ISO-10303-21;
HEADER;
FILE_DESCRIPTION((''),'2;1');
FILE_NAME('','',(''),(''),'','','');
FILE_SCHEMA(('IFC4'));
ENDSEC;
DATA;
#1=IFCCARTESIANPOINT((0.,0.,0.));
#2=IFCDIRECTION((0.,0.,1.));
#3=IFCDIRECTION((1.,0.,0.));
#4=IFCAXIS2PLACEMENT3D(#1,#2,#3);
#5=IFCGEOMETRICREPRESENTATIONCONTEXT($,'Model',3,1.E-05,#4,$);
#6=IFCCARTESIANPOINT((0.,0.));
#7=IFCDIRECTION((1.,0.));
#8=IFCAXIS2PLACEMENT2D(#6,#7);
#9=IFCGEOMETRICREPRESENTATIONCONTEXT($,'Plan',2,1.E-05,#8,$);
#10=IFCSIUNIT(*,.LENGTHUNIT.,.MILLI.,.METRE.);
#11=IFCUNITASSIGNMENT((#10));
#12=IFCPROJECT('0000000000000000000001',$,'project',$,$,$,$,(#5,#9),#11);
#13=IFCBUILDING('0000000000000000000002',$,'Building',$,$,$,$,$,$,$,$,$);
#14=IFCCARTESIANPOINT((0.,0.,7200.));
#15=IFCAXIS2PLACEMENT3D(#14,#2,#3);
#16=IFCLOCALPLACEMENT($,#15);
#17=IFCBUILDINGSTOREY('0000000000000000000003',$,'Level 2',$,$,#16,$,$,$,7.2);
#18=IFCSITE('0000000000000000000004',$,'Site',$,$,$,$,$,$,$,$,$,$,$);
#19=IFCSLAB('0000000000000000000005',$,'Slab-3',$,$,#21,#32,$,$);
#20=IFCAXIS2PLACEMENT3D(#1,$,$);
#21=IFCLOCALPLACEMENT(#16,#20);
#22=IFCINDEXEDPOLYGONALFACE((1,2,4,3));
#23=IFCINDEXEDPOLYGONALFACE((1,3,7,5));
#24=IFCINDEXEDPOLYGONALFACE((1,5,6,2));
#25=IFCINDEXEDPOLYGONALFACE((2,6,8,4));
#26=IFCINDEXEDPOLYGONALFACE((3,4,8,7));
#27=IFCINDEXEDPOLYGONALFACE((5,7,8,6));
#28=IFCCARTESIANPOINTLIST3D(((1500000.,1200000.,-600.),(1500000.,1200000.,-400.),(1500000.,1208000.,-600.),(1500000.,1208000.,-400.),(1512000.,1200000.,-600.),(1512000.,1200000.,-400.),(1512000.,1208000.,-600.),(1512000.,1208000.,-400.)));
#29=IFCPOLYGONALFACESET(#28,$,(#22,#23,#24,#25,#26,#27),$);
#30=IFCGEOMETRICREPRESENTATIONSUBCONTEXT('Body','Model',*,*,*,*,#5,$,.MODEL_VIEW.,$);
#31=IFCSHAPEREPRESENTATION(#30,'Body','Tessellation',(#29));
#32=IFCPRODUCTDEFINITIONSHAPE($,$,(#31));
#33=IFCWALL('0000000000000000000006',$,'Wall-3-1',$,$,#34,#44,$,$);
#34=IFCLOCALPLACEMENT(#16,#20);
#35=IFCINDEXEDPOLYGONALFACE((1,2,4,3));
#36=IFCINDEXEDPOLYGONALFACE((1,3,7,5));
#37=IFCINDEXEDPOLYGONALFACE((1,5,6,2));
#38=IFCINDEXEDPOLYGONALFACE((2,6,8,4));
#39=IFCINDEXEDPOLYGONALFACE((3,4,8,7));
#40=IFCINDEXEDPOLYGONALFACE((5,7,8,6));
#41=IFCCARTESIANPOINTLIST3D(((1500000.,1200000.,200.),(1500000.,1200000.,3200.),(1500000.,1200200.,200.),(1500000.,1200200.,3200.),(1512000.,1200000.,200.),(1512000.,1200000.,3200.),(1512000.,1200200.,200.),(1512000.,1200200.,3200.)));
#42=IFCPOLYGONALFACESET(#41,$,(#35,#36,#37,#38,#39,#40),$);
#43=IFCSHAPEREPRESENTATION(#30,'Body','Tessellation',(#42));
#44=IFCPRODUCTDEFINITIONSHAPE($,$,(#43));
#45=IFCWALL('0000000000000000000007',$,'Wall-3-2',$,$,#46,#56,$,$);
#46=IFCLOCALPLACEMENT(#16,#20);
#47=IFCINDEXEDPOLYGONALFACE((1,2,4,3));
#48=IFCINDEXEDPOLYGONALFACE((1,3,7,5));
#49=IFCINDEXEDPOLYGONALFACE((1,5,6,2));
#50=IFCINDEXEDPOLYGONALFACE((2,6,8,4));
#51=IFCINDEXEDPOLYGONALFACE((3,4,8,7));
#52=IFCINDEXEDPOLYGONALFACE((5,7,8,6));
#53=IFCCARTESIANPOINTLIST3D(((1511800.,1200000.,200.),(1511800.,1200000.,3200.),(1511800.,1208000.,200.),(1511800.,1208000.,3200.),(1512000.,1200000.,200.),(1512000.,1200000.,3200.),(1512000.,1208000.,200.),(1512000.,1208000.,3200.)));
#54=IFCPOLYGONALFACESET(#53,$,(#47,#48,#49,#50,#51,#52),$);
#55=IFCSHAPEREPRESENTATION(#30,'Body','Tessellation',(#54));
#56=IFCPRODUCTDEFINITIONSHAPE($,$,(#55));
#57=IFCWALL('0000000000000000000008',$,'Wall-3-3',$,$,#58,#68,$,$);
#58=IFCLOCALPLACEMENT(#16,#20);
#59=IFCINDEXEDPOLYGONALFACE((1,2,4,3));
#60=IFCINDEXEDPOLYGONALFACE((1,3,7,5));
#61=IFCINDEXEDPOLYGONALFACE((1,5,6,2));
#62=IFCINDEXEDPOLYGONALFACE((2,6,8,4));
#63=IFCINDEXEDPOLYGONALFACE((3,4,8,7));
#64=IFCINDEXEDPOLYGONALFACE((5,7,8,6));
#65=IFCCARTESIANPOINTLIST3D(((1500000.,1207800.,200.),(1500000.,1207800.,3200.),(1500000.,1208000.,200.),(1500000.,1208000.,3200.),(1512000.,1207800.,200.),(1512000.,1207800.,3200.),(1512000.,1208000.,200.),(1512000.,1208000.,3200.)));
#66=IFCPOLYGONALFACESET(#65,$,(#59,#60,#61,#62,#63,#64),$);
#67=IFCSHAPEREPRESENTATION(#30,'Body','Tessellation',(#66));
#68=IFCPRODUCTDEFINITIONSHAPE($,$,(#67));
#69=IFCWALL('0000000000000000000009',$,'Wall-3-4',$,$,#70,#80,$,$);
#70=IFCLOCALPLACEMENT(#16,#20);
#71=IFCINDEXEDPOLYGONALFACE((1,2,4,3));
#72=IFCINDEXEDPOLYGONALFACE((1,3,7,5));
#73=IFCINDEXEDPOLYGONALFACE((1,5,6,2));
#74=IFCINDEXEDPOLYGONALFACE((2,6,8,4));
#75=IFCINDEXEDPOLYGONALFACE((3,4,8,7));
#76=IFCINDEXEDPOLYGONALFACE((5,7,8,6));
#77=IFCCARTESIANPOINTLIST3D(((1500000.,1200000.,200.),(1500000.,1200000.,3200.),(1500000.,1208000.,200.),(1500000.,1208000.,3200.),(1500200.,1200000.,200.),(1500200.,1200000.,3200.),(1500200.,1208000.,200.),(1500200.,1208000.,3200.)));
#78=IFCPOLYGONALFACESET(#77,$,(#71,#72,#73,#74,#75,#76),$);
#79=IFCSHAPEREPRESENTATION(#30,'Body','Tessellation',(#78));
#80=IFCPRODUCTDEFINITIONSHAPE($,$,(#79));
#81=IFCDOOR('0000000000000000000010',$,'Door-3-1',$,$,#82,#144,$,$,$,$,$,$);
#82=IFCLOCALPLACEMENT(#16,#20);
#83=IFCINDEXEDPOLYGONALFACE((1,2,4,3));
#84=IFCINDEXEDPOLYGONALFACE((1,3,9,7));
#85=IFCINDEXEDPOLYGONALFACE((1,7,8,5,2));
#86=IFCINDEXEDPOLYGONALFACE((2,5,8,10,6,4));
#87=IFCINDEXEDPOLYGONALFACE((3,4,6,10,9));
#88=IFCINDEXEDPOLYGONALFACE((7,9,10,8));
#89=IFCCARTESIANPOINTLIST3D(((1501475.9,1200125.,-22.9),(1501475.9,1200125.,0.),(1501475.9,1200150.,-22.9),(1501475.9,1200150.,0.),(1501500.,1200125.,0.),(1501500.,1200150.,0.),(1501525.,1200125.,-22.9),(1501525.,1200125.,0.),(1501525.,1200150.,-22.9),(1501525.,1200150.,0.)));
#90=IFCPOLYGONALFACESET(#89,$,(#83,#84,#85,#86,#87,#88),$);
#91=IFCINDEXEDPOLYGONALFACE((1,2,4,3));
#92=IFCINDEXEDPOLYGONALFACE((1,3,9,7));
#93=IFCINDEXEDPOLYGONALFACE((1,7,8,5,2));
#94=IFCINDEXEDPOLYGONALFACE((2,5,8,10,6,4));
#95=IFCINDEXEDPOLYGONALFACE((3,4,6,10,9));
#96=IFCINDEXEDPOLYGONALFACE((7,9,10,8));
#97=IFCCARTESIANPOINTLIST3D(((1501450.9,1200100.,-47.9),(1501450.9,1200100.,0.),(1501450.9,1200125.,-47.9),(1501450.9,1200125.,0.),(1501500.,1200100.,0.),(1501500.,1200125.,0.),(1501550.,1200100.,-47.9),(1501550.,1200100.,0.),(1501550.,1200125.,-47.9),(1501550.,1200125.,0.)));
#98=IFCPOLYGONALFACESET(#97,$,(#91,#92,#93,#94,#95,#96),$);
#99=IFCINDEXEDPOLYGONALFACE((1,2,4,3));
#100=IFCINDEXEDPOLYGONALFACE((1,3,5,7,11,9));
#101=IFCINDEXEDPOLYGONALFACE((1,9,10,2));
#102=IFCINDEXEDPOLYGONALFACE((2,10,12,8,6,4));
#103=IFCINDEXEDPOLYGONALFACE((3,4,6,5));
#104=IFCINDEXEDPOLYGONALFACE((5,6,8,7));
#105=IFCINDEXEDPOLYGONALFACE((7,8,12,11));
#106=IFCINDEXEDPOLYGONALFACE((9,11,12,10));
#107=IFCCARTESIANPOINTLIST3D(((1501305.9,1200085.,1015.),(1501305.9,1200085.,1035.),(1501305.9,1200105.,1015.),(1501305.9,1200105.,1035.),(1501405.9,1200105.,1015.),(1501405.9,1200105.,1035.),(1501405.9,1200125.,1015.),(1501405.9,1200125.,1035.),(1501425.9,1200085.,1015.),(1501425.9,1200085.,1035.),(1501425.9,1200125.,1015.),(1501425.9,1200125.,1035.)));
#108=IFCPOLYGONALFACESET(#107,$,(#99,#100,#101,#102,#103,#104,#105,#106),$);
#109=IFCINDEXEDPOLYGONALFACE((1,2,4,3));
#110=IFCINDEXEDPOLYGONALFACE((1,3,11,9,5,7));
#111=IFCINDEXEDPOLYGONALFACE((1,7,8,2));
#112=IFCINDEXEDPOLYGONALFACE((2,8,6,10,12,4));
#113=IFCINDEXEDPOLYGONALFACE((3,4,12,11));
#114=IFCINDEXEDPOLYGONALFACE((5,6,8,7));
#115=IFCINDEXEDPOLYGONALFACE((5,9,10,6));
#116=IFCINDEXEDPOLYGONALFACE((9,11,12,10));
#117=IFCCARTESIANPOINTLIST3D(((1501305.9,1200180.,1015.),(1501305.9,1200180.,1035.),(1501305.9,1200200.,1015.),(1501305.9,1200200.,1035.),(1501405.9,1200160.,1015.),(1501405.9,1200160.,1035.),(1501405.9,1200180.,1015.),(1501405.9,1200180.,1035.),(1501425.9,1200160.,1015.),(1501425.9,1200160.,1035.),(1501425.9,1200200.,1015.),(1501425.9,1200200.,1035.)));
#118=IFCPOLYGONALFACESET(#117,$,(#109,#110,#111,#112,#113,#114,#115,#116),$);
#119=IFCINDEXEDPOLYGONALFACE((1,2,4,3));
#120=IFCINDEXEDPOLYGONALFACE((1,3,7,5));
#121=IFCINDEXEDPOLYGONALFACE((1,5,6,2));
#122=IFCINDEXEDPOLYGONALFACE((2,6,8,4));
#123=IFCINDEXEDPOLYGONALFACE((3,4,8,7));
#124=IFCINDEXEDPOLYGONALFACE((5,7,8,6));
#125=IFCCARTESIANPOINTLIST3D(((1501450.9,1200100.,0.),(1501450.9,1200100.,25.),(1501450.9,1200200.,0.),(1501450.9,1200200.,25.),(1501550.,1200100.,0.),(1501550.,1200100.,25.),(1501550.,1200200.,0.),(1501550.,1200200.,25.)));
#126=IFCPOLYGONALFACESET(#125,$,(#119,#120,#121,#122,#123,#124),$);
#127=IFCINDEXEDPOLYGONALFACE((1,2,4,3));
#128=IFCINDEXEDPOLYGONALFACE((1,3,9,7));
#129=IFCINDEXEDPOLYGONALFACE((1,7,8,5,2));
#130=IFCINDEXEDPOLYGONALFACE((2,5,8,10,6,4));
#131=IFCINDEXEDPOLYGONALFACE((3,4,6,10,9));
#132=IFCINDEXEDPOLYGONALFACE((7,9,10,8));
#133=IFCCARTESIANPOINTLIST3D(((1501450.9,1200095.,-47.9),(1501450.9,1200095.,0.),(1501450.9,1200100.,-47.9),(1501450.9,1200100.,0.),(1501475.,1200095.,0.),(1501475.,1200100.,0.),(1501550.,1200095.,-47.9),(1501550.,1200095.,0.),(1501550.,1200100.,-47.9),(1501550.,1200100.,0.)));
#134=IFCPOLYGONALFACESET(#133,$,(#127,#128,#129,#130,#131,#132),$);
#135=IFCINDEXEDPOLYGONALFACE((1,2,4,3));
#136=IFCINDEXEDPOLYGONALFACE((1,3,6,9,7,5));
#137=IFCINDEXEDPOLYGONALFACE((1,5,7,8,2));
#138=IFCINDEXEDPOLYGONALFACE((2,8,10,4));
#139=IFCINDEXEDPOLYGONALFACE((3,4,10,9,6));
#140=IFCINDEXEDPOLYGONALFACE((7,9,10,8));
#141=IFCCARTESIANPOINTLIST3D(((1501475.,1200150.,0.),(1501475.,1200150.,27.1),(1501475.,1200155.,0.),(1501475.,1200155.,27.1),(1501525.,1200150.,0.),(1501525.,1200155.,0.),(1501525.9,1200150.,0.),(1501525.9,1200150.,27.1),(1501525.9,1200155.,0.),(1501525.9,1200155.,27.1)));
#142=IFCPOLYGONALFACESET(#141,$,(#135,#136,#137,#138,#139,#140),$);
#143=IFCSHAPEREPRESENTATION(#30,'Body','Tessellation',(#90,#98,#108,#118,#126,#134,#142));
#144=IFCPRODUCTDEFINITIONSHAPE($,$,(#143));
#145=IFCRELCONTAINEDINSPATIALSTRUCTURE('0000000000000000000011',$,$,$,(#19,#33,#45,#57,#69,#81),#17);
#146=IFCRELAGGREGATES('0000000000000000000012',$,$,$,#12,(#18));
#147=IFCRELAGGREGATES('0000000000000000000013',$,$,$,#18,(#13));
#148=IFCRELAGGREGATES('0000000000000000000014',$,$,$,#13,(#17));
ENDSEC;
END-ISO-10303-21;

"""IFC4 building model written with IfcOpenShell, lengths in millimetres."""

from ifc_helpers import new_model, si_unit, frame, origin_with_axes, origin_2d_with_axis, place, context, subcontext, project, spatial, line, indexed_curve, outline, extrude, element, save


model = new_model("IFC4")

# Units and contexts
model_context = context("Model", 3, precision=1e-05, world=origin_with_axes())
plan_context = context("Plan", 2, precision=1e-05, world=origin_2d_with_axis())
body_context = subcontext(model_context, "Body", "Model", "MODEL_VIEW")
ifc_project = project(units=[si_unit("LENGTHUNIT", "METRE", prefix="MILLI")], contexts=[model_context, plan_context])

# Site, building, storey
site = spatial("IfcSite", under=ifc_project, Name="Site")
building = spatial("IfcBuilding", under=site, Name="Building")
storey_placement = place(None, frame((0.0, 0.0, 7200.0), z_axis=(0.0, 0.0, 1.0), x_axis=(1.0, 0.0, 0.0)))
storey = spatial("IfcBuildingStorey", under=building, at=storey_placement, Name="Level 2", Elevation=7.2)

# Slab
slab_placement = place(storey_placement, frame((1500000.0, 1200000.0, -600.0), z_axis=(0.0, 0.0, 1.0), x_axis=(1.0, 0.0, 0.0)))
element("IfcSlab", 1, at=slab_placement, inside=storey, Name="Slab-3", context=body_context, shape_type="SweptSolid", body=[
    extrude(outline(indexed_curve([(0.0, 0.0), (12000.0, 0.0), (12000.0, 8000.0), (0.0, 8000.0), (0.0, 0.0)])), None, (0.0, 0.0, 1.0), 200.0),
])

# Walls
wall_1_placement = place(storey_placement, frame((1500000.0, 1200000.0, 200.0), z_axis=(0.0, 0.0, 1.0), x_axis=(1.0, 0.0, 0.0)))
element("IfcWall", 2, at=wall_1_placement, inside=storey, Name="Wall-3-1", context=body_context, shape_type="SweptSolid", body=[
    extrude(outline(indexed_curve([(0.0, 0.0), (0.0, 200.0), (12000.0, 200.0), (12000.0, 0.0), (0.0, 0.0)], self_intersect=False)), origin_with_axes(), (0.0, 0.0, 1.0), 3000.0),
])
wall_2_placement = place(storey_placement, frame((1512000.0, 1200000.0, 200.0), z_axis=(0.0, 0.0, 1.0), x_axis=(0.0, 1.0, 0.0)))
element("IfcWall", 3, at=wall_2_placement, inside=storey, Name="Wall-3-2", context=body_context, shape_type="SweptSolid", body=[
    extrude(outline(indexed_curve([(0.0, 0.0), (0.0, 200.0), (8000.0, 200.0), (8000.0, 0.0), (0.0, 0.0)], self_intersect=False)), origin_with_axes(), (0.0, 0.0, 1.0), 3000.0),
])
wall_3_placement = place(storey_placement, frame((1512000.0, 1208000.0, 200.0), z_axis=(0.0, 0.0, 1.0), x_axis=(-1.0, 0.0, 0.0)))
element("IfcWall", 4, at=wall_3_placement, inside=storey, Name="Wall-3-3", context=body_context, shape_type="SweptSolid", body=[
    extrude(outline(indexed_curve([(0.0, 0.0), (0.0, 200.0), (12000.0, 200.0), (12000.0, 0.0), (0.0, 0.0)], self_intersect=False)), origin_with_axes(), (0.0, 0.0, 1.0), 3000.0),
])
wall_4_placement = place(storey_placement, frame((1500000.0, 1208000.0, 200.0), z_axis=(0.0, 0.0, 1.0), x_axis=(0.0, -1.0, 0.0)))
element("IfcWall", 5, at=wall_4_placement, inside=storey, Name="Wall-3-4", context=body_context, shape_type="SweptSolid", body=[
    extrude(outline(indexed_curve([(0.0, 0.0), (0.0, 200.0), (8000.0, 200.0), (8000.0, 0.0), (0.0, 0.0)], self_intersect=False)), origin_with_axes(), (0.0, 0.0, 1.0), 3000.0),
])

# Door
door_1_placement = place(storey_placement, frame((1501500.0, 1200100.0, 0.0), z_axis=(0.0, 0.0, 1.0), x_axis=(1.0, 0.0, 0.0)))
element("IfcDoor", 6, at=door_1_placement, inside=storey, Name="Door-3-1", context=body_context, shape_type="SweptSolid", body=[
    extrude(outline(indexed_curve([(0.0, 0.0), (0.0, 2.1), (0.9, 2.1), (0.9, 0.0), (-24.1, 0.0), (-24.1, -22.9), (25.0, -22.9), (25.0, 0.0)], segments=[line(1, 2, 3, 4, 5, 6, 7, 8, 1)])), frame((0.0, 25.0, 0.0), z_axis=(0.0, -1.0, 0.0), x_axis=(1.0, 0.0, 0.0)), (0.0, 0.0, -1.0), 25.0),
    extrude(outline(indexed_curve([(0.0, 0.0), (0.0, 2.1), (0.9, 2.1), (0.9, 0.0), (-49.1, 0.0), (-49.1, -47.9), (50.0, -47.9), (50.0, 0.0)], segments=[line(1, 2, 3, 4, 5, 6, 7, 8, 1)])), frame((0.0, 0.0, 0.0), z_axis=(0.0, -1.0, 0.0), x_axis=(1.0, 0.0, 0.0)), (0.0, 0.0, -1.0), 25.0),
    extrude(outline(indexed_curve([(0.0, 0.0), (-49.1, 0.0), (-49.1, 35.0), (0.0, 35.0)], segments=[line(1, 2, 3, 4, 1)])), frame((25.0, 25.0, 25.0), z_axis=(0.0, 0.0, 1.0), x_axis=(1.0, 0.0, 0.0)), (0.0, 0.0, 1.0), -47.9),
    extrude(outline(indexed_curve([(0.0, 0.0), (0.0, -40.0), (-120.0, -40.0), (-120.0, -20.0), (-20.0, -20.0), (-20.0, 0.0)], segments=[line(1, 2, 3, 4, 5, 6, 1)])), frame((-74.1, 25.0, 1015.0), z_axis=(0.0, 0.0, 1.0), x_axis=(1.0, 0.0, 0.0)), (0.0, 0.0, 1.0), 20.0),
    extrude(outline(indexed_curve([(0.0, 0.0), (0.0, 40.0), (-120.0, 40.0), (-120.0, 20.0), (-20.0, 20.0), (-20.0, 0.0)], segments=[line(1, 2, 3, 4, 5, 6, 1)])), frame((-74.1, 60.0, 1015.0), z_axis=(0.0, 0.0, 1.0), x_axis=(1.0, 0.0, 0.0)), (0.0, 0.0, 1.0), 20.0),
    extrude(outline(indexed_curve([(0.0, 0.0), (-99.1, 0.0), (-99.1, 100.0), (0.0, 100.0)], segments=[line(1, 2, 3, 4, 1)])), frame((50.0, 0.0, 0.0), z_axis=(0.0, 0.0, 1.0), x_axis=(1.0, 0.0, 0.0)), (0.0, 0.0, 1.0), 25.0),
    extrude(outline(indexed_curve([(0.0, 0.0), (0.0, 27.1), (50.9, 27.1), (50.9, 0.0), (-24.1, 0.0), (-24.1, -47.9), (75.0, -47.9), (75.0, 0.0)], segments=[line(1, 2, 3, 4, 5, 6, 7, 8, 1)])), frame((-25.0, -5.0, 0.0), z_axis=(0.0, -1.0, 0.0), x_axis=(1.0, 0.0, 0.0)), (0.0, 0.0, -1.0), 5.0),
    extrude(outline(indexed_curve([(0.0, 0.0), (0.0, 27.1), (50.9, 27.1), (50.9, 0.0), (0.9, 0.0), (0.9, -22.9), (50.0, -22.9), (50.0, 0.0)], segments=[line(1, 2, 3, 4, 5, 6, 7, 8, 1)])), frame((-25.0, 50.0, 0.0), z_axis=(0.0, -1.0, 0.0), x_axis=(1.0, 0.0, 0.0)), (0.0, 0.0, -1.0), 5.0),
])

save(model, "model.ifc")
